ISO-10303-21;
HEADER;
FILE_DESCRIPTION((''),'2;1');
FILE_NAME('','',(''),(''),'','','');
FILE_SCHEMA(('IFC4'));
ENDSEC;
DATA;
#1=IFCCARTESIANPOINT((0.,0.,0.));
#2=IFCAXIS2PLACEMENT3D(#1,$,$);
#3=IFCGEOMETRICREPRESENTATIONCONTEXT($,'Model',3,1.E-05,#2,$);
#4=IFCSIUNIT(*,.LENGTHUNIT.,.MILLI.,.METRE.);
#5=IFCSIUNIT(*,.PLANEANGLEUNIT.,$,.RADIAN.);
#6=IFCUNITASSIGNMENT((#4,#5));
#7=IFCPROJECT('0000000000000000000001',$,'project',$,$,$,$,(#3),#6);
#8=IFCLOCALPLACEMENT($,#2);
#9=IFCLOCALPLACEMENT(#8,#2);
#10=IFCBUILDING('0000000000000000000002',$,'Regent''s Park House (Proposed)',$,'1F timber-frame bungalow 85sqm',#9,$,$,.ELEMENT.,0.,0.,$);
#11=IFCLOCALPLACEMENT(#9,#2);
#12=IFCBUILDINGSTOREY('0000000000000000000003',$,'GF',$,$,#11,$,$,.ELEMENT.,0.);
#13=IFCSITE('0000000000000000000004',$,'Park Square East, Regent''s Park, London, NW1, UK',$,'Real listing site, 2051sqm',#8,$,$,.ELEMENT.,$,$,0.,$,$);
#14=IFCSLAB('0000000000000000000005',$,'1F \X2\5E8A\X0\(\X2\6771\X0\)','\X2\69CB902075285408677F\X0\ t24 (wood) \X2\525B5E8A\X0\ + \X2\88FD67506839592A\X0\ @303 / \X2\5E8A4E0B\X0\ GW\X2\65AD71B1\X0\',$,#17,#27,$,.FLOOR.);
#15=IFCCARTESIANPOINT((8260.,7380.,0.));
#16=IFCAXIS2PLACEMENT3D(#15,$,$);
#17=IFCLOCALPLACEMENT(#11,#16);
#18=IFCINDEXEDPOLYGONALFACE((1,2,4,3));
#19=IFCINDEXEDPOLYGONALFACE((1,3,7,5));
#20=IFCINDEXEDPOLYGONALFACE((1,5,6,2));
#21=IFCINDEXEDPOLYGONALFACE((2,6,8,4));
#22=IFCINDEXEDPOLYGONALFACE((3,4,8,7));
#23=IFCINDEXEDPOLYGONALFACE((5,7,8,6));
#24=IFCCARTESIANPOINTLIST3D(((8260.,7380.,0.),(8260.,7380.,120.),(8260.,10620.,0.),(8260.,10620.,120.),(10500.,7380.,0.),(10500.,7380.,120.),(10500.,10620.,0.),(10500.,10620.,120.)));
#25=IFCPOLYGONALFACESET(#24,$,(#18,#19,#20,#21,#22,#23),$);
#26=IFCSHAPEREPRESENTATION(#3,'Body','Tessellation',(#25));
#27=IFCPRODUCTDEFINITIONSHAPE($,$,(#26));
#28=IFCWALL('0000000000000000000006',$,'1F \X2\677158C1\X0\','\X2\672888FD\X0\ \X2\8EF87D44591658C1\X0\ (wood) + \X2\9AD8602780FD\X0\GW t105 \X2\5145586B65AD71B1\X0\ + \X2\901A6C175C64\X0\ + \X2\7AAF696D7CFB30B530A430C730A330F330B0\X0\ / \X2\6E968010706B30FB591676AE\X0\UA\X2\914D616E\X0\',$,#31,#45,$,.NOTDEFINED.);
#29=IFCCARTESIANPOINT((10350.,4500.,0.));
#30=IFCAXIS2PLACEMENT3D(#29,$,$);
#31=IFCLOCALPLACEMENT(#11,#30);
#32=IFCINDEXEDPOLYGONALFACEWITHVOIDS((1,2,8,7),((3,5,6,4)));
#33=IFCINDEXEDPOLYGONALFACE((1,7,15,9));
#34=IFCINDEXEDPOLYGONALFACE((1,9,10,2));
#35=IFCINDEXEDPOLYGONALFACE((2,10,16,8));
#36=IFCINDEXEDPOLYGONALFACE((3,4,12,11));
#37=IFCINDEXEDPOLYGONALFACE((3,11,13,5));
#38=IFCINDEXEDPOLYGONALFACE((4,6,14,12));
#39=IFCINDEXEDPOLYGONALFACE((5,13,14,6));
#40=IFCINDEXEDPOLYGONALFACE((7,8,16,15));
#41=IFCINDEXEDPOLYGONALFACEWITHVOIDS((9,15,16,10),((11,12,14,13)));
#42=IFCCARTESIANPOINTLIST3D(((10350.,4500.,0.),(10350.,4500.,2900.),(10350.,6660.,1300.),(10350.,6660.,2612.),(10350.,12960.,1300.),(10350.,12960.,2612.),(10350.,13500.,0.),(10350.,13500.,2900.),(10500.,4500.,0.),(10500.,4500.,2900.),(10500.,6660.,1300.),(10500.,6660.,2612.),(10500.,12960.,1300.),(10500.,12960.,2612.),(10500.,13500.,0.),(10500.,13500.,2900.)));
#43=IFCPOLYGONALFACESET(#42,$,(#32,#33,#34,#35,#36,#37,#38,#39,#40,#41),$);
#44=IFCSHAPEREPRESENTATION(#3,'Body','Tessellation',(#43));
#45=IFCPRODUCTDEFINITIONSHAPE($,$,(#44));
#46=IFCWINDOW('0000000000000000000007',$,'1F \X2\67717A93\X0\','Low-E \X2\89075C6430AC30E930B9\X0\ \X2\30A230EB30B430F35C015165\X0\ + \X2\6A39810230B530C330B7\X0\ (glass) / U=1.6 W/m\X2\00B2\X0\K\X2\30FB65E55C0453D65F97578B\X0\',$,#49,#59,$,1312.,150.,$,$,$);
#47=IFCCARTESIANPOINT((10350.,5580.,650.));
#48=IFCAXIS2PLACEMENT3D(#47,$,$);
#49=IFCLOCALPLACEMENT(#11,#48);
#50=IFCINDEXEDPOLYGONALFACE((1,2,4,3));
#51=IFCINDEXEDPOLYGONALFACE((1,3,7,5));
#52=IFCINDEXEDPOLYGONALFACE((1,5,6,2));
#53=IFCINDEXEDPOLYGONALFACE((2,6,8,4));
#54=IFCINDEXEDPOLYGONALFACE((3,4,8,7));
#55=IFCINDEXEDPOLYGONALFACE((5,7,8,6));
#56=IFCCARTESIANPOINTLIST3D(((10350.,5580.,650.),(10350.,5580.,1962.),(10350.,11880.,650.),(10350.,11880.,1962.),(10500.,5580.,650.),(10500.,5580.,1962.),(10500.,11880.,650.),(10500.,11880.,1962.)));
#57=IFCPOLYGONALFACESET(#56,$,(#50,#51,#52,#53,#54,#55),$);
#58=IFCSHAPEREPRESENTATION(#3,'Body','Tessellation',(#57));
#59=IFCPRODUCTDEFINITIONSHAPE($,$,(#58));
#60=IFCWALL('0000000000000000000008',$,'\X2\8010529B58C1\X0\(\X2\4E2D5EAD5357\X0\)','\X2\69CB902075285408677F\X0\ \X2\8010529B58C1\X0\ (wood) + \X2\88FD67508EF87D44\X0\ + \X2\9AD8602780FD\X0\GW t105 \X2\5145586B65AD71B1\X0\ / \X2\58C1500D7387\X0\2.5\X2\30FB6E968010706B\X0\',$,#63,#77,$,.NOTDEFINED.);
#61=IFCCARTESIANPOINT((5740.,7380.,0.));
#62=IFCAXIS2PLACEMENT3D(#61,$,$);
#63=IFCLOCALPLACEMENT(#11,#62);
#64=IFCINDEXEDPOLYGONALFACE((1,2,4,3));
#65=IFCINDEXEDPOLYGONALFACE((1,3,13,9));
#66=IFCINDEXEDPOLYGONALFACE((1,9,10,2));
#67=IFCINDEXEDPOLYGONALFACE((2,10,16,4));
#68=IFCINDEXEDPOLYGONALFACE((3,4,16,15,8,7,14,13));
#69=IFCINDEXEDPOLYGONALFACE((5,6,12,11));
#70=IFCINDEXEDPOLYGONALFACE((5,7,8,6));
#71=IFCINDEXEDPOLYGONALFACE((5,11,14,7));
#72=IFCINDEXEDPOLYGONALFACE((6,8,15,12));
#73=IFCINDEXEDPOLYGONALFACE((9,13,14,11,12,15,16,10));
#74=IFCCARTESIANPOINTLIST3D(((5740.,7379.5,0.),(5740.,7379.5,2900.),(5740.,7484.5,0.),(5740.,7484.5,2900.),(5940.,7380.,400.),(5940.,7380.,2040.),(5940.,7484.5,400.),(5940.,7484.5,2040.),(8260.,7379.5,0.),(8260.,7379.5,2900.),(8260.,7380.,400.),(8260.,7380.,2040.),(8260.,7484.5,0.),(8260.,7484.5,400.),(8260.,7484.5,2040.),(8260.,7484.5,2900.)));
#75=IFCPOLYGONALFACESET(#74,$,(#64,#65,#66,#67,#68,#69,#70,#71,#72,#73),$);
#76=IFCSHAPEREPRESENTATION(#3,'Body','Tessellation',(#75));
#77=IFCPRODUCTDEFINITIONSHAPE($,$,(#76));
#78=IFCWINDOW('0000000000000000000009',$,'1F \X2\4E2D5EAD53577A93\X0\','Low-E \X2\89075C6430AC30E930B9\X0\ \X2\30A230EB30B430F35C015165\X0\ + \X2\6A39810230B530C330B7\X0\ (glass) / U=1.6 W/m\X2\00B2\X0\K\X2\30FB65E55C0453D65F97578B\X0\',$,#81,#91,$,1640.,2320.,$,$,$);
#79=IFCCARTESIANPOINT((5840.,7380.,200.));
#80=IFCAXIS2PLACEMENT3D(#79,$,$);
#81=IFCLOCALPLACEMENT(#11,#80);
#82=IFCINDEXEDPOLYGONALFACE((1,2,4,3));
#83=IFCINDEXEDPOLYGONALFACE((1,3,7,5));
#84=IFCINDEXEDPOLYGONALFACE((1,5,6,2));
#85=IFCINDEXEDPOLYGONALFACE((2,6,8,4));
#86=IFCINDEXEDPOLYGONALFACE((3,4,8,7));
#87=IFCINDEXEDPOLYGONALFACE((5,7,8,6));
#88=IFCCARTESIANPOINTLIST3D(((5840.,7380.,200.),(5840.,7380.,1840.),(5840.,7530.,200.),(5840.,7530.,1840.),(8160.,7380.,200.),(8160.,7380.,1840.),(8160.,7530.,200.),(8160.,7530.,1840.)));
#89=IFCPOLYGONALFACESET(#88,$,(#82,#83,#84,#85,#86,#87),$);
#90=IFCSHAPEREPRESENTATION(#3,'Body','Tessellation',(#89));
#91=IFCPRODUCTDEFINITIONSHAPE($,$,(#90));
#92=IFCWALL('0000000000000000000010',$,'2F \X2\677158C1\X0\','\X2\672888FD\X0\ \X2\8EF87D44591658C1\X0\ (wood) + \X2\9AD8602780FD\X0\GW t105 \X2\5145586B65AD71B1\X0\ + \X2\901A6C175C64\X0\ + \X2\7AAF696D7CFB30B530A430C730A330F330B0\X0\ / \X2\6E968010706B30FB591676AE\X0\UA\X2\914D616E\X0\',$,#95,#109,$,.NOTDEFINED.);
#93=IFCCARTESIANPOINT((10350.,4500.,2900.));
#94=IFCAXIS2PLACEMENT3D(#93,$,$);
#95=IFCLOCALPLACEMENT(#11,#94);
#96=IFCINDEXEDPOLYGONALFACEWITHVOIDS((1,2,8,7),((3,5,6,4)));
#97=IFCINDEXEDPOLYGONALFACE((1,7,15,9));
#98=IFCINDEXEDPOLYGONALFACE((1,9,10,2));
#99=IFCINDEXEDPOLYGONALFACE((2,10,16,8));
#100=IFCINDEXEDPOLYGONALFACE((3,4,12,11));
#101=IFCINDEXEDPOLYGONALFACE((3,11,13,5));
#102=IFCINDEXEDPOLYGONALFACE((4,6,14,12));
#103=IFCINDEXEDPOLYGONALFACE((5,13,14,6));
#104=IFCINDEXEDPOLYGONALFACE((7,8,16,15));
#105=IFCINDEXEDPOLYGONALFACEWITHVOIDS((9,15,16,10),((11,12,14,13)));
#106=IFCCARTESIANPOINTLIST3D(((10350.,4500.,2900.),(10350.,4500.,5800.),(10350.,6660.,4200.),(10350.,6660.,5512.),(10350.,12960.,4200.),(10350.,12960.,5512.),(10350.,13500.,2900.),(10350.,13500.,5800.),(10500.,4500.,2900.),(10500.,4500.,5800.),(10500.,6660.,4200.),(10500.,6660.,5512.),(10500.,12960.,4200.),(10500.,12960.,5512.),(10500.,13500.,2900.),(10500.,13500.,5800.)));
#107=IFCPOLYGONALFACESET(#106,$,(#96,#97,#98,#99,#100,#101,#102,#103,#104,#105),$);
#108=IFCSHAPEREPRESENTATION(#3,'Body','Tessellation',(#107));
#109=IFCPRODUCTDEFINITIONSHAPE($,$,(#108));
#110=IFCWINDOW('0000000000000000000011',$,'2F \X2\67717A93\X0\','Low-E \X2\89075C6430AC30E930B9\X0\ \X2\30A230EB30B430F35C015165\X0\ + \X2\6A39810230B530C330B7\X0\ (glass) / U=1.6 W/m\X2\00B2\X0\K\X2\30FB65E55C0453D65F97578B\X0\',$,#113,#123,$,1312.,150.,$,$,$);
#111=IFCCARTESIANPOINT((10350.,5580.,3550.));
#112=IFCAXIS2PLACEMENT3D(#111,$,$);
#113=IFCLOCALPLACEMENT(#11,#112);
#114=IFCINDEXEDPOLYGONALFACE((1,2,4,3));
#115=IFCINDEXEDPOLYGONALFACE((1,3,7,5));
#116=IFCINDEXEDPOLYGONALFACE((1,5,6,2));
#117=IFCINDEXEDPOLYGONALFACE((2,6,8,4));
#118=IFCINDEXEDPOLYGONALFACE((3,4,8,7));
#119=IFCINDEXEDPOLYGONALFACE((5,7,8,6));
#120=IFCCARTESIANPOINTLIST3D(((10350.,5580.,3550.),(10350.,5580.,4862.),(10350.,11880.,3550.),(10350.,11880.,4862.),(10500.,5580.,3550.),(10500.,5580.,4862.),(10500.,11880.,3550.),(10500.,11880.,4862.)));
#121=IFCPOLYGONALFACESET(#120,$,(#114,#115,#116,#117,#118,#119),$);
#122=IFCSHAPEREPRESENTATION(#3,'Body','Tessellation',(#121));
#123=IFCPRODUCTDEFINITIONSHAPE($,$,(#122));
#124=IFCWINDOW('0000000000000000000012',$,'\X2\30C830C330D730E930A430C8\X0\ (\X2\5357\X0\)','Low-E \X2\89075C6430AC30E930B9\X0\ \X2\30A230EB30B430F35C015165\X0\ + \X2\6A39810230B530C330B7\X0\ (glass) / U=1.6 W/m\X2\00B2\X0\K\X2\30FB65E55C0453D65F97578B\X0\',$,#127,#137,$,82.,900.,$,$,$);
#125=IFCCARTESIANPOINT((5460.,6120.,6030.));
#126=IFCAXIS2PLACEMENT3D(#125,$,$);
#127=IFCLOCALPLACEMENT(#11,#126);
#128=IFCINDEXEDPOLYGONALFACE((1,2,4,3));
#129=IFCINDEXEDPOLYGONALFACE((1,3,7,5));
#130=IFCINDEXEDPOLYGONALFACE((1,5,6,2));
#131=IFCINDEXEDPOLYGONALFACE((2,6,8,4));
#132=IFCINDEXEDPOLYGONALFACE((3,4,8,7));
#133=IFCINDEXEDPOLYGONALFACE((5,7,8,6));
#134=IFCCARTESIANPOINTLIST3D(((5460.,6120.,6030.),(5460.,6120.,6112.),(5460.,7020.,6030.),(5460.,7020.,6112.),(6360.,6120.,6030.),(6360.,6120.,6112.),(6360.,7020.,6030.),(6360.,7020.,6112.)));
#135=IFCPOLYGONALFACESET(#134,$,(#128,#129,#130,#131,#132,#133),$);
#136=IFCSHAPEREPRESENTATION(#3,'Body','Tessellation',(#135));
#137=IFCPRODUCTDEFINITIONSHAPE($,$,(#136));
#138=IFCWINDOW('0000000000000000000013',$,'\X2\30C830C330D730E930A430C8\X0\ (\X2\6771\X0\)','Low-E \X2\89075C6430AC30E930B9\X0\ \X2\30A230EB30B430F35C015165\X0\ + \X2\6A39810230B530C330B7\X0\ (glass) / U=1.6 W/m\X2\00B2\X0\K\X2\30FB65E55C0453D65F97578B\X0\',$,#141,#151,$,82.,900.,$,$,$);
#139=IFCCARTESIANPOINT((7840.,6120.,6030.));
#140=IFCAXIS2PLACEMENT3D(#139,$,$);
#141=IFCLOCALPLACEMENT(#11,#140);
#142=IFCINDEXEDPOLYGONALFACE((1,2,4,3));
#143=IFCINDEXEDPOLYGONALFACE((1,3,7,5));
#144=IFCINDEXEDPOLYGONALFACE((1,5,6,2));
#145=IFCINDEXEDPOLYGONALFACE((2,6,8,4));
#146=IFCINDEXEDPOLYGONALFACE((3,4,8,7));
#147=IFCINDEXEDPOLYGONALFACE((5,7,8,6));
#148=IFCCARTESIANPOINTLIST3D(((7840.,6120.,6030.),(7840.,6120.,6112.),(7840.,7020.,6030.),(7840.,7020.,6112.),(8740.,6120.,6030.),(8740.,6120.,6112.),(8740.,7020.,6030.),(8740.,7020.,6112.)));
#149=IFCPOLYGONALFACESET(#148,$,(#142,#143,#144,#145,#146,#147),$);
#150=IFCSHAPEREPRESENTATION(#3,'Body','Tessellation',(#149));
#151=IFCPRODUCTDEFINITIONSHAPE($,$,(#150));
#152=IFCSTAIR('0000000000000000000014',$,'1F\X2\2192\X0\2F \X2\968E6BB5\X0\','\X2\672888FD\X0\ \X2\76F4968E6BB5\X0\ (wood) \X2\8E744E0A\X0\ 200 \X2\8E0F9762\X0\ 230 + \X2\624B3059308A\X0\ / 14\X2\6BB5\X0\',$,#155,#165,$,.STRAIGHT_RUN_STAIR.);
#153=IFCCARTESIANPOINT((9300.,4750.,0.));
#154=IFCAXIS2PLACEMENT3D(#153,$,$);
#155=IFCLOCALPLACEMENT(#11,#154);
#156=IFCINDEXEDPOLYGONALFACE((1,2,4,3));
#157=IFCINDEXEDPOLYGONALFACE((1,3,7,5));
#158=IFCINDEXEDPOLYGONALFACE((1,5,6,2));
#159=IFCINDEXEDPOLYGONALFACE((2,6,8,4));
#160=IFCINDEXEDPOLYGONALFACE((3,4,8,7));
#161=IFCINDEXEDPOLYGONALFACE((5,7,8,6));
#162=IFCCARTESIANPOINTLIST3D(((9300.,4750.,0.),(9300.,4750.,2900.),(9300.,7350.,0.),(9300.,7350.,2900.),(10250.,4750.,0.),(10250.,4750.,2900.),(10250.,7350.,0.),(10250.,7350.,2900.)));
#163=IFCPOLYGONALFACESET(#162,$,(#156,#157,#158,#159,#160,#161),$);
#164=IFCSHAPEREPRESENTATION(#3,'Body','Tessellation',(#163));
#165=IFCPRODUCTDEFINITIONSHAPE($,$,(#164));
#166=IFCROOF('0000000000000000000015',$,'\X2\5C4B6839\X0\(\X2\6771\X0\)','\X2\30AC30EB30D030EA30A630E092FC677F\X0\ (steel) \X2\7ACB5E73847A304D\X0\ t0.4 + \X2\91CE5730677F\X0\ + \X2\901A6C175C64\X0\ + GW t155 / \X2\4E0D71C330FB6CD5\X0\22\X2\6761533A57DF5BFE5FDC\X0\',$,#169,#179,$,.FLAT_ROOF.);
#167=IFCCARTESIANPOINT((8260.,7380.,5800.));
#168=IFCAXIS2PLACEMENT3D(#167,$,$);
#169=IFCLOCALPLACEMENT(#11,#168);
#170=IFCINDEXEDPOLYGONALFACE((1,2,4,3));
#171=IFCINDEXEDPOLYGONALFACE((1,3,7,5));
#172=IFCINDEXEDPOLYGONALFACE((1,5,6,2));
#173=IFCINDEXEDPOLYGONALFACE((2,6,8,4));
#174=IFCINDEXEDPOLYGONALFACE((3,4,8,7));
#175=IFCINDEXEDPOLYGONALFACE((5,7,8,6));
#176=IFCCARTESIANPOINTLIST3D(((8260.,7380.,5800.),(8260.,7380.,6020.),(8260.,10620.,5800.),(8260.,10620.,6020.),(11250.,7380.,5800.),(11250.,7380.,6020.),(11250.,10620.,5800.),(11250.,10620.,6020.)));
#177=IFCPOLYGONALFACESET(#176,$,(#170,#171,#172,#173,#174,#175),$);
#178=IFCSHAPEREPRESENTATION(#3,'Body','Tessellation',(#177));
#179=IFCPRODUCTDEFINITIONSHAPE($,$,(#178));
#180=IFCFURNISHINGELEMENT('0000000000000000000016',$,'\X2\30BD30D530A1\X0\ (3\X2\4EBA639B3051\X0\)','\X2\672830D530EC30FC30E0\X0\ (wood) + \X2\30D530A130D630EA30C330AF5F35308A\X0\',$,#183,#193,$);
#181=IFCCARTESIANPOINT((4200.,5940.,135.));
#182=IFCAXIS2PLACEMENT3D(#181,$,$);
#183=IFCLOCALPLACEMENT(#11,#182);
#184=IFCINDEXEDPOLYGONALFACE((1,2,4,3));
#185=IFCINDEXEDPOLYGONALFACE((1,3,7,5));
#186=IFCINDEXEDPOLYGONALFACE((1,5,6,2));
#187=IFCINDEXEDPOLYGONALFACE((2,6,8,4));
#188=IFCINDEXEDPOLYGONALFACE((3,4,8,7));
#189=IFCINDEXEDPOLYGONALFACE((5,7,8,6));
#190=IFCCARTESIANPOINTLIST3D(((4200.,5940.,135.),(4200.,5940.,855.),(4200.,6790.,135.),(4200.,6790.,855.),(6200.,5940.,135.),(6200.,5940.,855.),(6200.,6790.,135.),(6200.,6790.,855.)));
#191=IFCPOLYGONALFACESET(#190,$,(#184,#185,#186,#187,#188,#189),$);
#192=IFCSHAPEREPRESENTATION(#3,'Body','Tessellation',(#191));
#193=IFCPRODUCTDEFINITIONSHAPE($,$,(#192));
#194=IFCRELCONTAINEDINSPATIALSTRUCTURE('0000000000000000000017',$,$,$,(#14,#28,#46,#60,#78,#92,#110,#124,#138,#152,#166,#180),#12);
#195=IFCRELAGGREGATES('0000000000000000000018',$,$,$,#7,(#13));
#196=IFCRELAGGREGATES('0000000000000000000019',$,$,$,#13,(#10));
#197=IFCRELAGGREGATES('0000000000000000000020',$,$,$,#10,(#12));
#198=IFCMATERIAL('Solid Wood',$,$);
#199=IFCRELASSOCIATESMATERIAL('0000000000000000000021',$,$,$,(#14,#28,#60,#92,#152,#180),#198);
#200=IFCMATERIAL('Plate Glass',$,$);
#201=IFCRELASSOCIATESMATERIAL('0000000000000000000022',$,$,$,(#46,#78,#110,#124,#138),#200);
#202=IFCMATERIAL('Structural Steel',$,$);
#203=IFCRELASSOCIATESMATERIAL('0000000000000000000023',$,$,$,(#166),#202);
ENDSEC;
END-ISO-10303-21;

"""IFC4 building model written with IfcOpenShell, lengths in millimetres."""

from ifc_helpers import new_model, si_unit, frame, frame_2d, origin, place, context, project, spatial, rectangle, extrude, material, element, fill, save


model = new_model("IFC4")

# Units and contexts
model_context = context("Model", 3, precision=1e-05, world=origin())
ifc_project = project(units=[si_unit("LENGTHUNIT", "METRE", prefix="MILLI"), si_unit("PLANEANGLEUNIT", "RADIAN")], contexts=[model_context])

# Site, building, storey
site_placement = place(None, origin())
site = spatial("IfcSite", under=ifc_project, at=site_placement, Name="Park Square East, Regent's Park, London, NW1, UK", ObjectType="Real listing site, 2051sqm", CompositionType="ELEMENT", RefElevation=0.0)
building_placement = place(site_placement, origin())
building = spatial("IfcBuilding", under=site, at=building_placement, Name="Regent's Park House (Proposed)", ObjectType="1F timber-frame bungalow 85sqm", CompositionType="ELEMENT", ElevationOfRefHeight=0.0, ElevationOfTerrain=0.0)
storey_placement = place(building_placement, origin())
storey = spatial("IfcBuildingStorey", under=building, at=storey_placement, Name="GF", CompositionType="ELEMENT", Elevation=0.0)

# Slab
ifc_material_1 = material(Name="Solid Wood")
slab_placement = place(storey_placement, frame((8260.0, 7380.0, 0.0)))
element("IfcSlab", 1, at=slab_placement, inside=storey, material=ifc_material_1, Name="1F 床(東)", Description="構造用合板 t24 (wood) 剛床 + 製材根太 @303 / 床下 GW断熱", PredefinedType="FLOOR", context=model_context, shape_type="SweptSolid", body=[
    extrude(rectangle(XDim=2240.0, YDim=3240.0, at=frame_2d((1120.0, 1620.0))), frame((8260.0, 7380.0, 0.0)), (0.0, 0.0, 1.0), 120.0),
])

# Walls, openings, windows
wall_1_placement = place(storey_placement, frame((10350.0, 4500.0, 0.0)))
wall_1 = element("IfcWall", 2, at=wall_1_placement, inside=storey, material=ifc_material_1, Name="1F 東壁", Description="木製 軸組外壁 (wood) + 高性能GW t105 充填断熱 + 通気層 + 窯業系サイディング / 準耐火・外皮UA配慮", PredefinedType="NOTDEFINED", context=model_context, shape_type="SweptSolid", body=[
    extrude(rectangle(XDim=150.0, YDim=9000.0, at=frame_2d((75.0, 4500.0))), frame((10350.0, 4500.0, 0.0)), (0.0, 0.0, 1.0), 2900.0),
])
opening_1_placement = place(storey_placement, frame((10350.0, 5580.0, 650.0)))
opening_1 = element("IfcOpeningElement", 3, at=opening_1_placement, cuts=wall_1, PredefinedType="NOTDEFINED", context=model_context, shape_type="SweptSolid", body=[
    extrude(rectangle(XDim=150.0, YDim=6300.0, at=frame_2d((75.0, 3150.0))), frame((10350.0, 5580.0, 650.0)), (0.0, 0.0, 1.0), 1312.0),
])
ifc_material_2 = material(Name="Plate Glass")
window_1_placement = place(storey_placement, frame((10350.0, 5580.0, 650.0)))
window_1 = element("IfcWindow", 4, at=window_1_placement, inside=storey, material=ifc_material_2, Name="1F 東窓", Description="Low-E 複層ガラス アルゴン封入 + 樹脂サッシ (glass) / U=1.6 W/m²K・日射取得型", OverallHeight=1312.0, OverallWidth=150.0, context=model_context, shape_type="SweptSolid", body=[
    extrude(rectangle(XDim=150.0, YDim=6300.0, at=frame_2d((75.0, 3150.0))), frame((10350.0, 5580.0, 650.0)), (0.0, 0.0, 1.0), 1312.0),
])
fill(opening_1, window_1)
wall_2_placement = place(storey_placement, frame((5740.0, 7380.0, 0.0)))
wall_2 = element("IfcWall", 5, at=wall_2_placement, inside=storey, material=ifc_material_1, Name="耐力壁(中庭南)", Description="構造用合板 耐力壁 (wood) + 製材軸組 + 高性能GW t105 充填断熱 / 壁倍率2.5・準耐火", PredefinedType="NOTDEFINED", context=model_context, shape_type="SweptSolid", body=[
    extrude(rectangle(XDim=2520.0, YDim=105.0, at=frame_2d((1260.0, 52.0))), frame((5740.0, 7380.0, 0.0)), (0.0, 0.0, 1.0), 2900.0),
])
opening_2_placement = place(storey_placement, frame((5840.0, 7380.0, 200.0)))
opening_2 = element("IfcOpeningElement", 6, at=opening_2_placement, cuts=wall_2, PredefinedType="NOTDEFINED", context=model_context, shape_type="SweptSolid", body=[
    extrude(rectangle(XDim=2320.0, YDim=150.0, at=frame_2d((1160.0, 75.0))), frame((5840.0, 7380.0, 200.0)), (0.0, 0.0, 1.0), 1640.0),
])
window_2_placement = place(storey_placement, frame((5840.0, 7380.0, 200.0)))
window_2 = element("IfcWindow", 7, at=window_2_placement, inside=storey, material=ifc_material_2, Name="1F 中庭南窓", Description="Low-E 複層ガラス アルゴン封入 + 樹脂サッシ (glass) / U=1.6 W/m²K・日射取得型", OverallHeight=1640.0, OverallWidth=2320.0, context=model_context, shape_type="SweptSolid", body=[
    extrude(rectangle(XDim=2320.0, YDim=150.0, at=frame_2d((1160.0, 75.0))), frame((5840.0, 7380.0, 200.0)), (0.0, 0.0, 1.0), 1640.0),
])
fill(opening_2, window_2)

# Wall, opening, window
wall_3_placement = place(storey_placement, frame((10350.0, 4500.0, 2900.0)))
wall_3 = element("IfcWall", 8, at=wall_3_placement, inside=storey, material=ifc_material_1, Name="2F 東壁", Description="木製 軸組外壁 (wood) + 高性能GW t105 充填断熱 + 通気層 + 窯業系サイディング / 準耐火・外皮UA配慮", PredefinedType="NOTDEFINED", context=model_context, shape_type="SweptSolid", body=[
    extrude(rectangle(XDim=150.0, YDim=9000.0, at=frame_2d((75.0, 4500.0))), frame((10350.0, 4500.0, 2900.0)), (0.0, 0.0, 1.0), 2900.0),
])
opening_3_placement = place(storey_placement, frame((10350.0, 5580.0, 3550.0)))
opening_3 = element("IfcOpeningElement", 9, at=opening_3_placement, cuts=wall_3, PredefinedType="NOTDEFINED", context=model_context, shape_type="SweptSolid", body=[
    extrude(rectangle(XDim=150.0, YDim=6300.0, at=frame_2d((75.0, 3150.0))), frame((10350.0, 5580.0, 3550.0)), (0.0, 0.0, 1.0), 1312.0),
])
window_3_placement = place(storey_placement, frame((10350.0, 5580.0, 3550.0)))
window_3 = element("IfcWindow", 10, at=window_3_placement, inside=storey, material=ifc_material_2, Name="2F 東窓", Description="Low-E 複層ガラス アルゴン封入 + 樹脂サッシ (glass) / U=1.6 W/m²K・日射取得型", OverallHeight=1312.0, OverallWidth=150.0, context=model_context, shape_type="SweptSolid", body=[
    extrude(rectangle(XDim=150.0, YDim=6300.0, at=frame_2d((75.0, 3150.0))), frame((10350.0, 5580.0, 3550.0)), (0.0, 0.0, 1.0), 1312.0),
])
fill(opening_3, window_3)

# Windows
window_4_placement = place(storey_placement, frame((5460.0, 6120.0, 6030.0)))
element("IfcWindow", 11, at=window_4_placement, inside=storey, material=ifc_material_2, Name="トップライト (南)", Description="Low-E 複層ガラス アルゴン封入 + 樹脂サッシ (glass) / U=1.6 W/m²K・日射取得型", OverallHeight=82.0, OverallWidth=900.0, context=model_context, shape_type="SweptSolid", body=[
    extrude(rectangle(XDim=900.0, YDim=900.0, at=frame_2d((450.0, 450.0))), frame((5460.0, 6120.0, 6030.0)), (0.0, 0.0, 1.0), 82.0),
])
window_5_placement = place(storey_placement, frame((7840.0, 6120.0, 6030.0)))
element("IfcWindow", 12, at=window_5_placement, inside=storey, material=ifc_material_2, Name="トップライト (東)", Description="Low-E 複層ガラス アルゴン封入 + 樹脂サッシ (glass) / U=1.6 W/m²K・日射取得型", OverallHeight=82.0, OverallWidth=900.0, context=model_context, shape_type="SweptSolid", body=[
    extrude(rectangle(XDim=900.0, YDim=900.0, at=frame_2d((450.0, 450.0))), frame((7840.0, 6120.0, 6030.0)), (0.0, 0.0, 1.0), 82.0),
])

# Stair
stair_placement = place(storey_placement, frame((9300.0, 4750.0, 0.0)))
element("IfcStair", 13, at=stair_placement, inside=storey, material=ifc_material_1, Name="1F→2F 階段", Description="木製 直階段 (wood) 蹴上 200 踏面 230 + 手すり / 14段", PredefinedType="STRAIGHT_RUN_STAIR", context=model_context, shape_type="SweptSolid", body=[
    extrude(rectangle(XDim=950.0, YDim=2600.0, at=frame_2d((475.0, 1300.0))), frame((9300.0, 4750.0, 0.0)), (0.0, 0.0, 1.0), 2900.0),
])

# Roof
ifc_material_3 = material(Name="Structural Steel")
roof_placement = place(storey_placement, frame((8260.0, 7380.0, 5800.0)))
element("IfcRoof", 14, at=roof_placement, inside=storey, material=ifc_material_3, Name="屋根(東)", Description="ガルバリウム鋼板 (steel) 立平葺き t0.4 + 野地板 + 通気層 + GW t155 / 不燃・法22条区域対応", PredefinedType="FLAT_ROOF", context=model_context, shape_type="SweptSolid", body=[
    extrude(rectangle(XDim=2990.0, YDim=3240.0, at=frame_2d((1495.0, 1620.0))), frame((8260.0, 7380.0, 5800.0)), (0.0, 0.0, 1.0), 220.0),
])

# Furnishing element
furnishing_1_placement = place(storey_placement, frame((4200.0, 5940.0, 135.0)))
element("IfcFurnishingElement", 15, at=furnishing_1_placement, inside=storey, material=ifc_material_1, Name="ソファ (3人掛け)", Description="木フレーム (wood) + ファブリック張り", context=model_context, shape_type="SweptSolid", body=[
    extrude(rectangle(XDim=2000.0, YDim=850.0, at=frame_2d((1000.0, 425.0))), frame((4200.0, 5940.0, 135.0)), (0.0, 0.0, 1.0), 720.0),
])

save(model, "model.ifc")
